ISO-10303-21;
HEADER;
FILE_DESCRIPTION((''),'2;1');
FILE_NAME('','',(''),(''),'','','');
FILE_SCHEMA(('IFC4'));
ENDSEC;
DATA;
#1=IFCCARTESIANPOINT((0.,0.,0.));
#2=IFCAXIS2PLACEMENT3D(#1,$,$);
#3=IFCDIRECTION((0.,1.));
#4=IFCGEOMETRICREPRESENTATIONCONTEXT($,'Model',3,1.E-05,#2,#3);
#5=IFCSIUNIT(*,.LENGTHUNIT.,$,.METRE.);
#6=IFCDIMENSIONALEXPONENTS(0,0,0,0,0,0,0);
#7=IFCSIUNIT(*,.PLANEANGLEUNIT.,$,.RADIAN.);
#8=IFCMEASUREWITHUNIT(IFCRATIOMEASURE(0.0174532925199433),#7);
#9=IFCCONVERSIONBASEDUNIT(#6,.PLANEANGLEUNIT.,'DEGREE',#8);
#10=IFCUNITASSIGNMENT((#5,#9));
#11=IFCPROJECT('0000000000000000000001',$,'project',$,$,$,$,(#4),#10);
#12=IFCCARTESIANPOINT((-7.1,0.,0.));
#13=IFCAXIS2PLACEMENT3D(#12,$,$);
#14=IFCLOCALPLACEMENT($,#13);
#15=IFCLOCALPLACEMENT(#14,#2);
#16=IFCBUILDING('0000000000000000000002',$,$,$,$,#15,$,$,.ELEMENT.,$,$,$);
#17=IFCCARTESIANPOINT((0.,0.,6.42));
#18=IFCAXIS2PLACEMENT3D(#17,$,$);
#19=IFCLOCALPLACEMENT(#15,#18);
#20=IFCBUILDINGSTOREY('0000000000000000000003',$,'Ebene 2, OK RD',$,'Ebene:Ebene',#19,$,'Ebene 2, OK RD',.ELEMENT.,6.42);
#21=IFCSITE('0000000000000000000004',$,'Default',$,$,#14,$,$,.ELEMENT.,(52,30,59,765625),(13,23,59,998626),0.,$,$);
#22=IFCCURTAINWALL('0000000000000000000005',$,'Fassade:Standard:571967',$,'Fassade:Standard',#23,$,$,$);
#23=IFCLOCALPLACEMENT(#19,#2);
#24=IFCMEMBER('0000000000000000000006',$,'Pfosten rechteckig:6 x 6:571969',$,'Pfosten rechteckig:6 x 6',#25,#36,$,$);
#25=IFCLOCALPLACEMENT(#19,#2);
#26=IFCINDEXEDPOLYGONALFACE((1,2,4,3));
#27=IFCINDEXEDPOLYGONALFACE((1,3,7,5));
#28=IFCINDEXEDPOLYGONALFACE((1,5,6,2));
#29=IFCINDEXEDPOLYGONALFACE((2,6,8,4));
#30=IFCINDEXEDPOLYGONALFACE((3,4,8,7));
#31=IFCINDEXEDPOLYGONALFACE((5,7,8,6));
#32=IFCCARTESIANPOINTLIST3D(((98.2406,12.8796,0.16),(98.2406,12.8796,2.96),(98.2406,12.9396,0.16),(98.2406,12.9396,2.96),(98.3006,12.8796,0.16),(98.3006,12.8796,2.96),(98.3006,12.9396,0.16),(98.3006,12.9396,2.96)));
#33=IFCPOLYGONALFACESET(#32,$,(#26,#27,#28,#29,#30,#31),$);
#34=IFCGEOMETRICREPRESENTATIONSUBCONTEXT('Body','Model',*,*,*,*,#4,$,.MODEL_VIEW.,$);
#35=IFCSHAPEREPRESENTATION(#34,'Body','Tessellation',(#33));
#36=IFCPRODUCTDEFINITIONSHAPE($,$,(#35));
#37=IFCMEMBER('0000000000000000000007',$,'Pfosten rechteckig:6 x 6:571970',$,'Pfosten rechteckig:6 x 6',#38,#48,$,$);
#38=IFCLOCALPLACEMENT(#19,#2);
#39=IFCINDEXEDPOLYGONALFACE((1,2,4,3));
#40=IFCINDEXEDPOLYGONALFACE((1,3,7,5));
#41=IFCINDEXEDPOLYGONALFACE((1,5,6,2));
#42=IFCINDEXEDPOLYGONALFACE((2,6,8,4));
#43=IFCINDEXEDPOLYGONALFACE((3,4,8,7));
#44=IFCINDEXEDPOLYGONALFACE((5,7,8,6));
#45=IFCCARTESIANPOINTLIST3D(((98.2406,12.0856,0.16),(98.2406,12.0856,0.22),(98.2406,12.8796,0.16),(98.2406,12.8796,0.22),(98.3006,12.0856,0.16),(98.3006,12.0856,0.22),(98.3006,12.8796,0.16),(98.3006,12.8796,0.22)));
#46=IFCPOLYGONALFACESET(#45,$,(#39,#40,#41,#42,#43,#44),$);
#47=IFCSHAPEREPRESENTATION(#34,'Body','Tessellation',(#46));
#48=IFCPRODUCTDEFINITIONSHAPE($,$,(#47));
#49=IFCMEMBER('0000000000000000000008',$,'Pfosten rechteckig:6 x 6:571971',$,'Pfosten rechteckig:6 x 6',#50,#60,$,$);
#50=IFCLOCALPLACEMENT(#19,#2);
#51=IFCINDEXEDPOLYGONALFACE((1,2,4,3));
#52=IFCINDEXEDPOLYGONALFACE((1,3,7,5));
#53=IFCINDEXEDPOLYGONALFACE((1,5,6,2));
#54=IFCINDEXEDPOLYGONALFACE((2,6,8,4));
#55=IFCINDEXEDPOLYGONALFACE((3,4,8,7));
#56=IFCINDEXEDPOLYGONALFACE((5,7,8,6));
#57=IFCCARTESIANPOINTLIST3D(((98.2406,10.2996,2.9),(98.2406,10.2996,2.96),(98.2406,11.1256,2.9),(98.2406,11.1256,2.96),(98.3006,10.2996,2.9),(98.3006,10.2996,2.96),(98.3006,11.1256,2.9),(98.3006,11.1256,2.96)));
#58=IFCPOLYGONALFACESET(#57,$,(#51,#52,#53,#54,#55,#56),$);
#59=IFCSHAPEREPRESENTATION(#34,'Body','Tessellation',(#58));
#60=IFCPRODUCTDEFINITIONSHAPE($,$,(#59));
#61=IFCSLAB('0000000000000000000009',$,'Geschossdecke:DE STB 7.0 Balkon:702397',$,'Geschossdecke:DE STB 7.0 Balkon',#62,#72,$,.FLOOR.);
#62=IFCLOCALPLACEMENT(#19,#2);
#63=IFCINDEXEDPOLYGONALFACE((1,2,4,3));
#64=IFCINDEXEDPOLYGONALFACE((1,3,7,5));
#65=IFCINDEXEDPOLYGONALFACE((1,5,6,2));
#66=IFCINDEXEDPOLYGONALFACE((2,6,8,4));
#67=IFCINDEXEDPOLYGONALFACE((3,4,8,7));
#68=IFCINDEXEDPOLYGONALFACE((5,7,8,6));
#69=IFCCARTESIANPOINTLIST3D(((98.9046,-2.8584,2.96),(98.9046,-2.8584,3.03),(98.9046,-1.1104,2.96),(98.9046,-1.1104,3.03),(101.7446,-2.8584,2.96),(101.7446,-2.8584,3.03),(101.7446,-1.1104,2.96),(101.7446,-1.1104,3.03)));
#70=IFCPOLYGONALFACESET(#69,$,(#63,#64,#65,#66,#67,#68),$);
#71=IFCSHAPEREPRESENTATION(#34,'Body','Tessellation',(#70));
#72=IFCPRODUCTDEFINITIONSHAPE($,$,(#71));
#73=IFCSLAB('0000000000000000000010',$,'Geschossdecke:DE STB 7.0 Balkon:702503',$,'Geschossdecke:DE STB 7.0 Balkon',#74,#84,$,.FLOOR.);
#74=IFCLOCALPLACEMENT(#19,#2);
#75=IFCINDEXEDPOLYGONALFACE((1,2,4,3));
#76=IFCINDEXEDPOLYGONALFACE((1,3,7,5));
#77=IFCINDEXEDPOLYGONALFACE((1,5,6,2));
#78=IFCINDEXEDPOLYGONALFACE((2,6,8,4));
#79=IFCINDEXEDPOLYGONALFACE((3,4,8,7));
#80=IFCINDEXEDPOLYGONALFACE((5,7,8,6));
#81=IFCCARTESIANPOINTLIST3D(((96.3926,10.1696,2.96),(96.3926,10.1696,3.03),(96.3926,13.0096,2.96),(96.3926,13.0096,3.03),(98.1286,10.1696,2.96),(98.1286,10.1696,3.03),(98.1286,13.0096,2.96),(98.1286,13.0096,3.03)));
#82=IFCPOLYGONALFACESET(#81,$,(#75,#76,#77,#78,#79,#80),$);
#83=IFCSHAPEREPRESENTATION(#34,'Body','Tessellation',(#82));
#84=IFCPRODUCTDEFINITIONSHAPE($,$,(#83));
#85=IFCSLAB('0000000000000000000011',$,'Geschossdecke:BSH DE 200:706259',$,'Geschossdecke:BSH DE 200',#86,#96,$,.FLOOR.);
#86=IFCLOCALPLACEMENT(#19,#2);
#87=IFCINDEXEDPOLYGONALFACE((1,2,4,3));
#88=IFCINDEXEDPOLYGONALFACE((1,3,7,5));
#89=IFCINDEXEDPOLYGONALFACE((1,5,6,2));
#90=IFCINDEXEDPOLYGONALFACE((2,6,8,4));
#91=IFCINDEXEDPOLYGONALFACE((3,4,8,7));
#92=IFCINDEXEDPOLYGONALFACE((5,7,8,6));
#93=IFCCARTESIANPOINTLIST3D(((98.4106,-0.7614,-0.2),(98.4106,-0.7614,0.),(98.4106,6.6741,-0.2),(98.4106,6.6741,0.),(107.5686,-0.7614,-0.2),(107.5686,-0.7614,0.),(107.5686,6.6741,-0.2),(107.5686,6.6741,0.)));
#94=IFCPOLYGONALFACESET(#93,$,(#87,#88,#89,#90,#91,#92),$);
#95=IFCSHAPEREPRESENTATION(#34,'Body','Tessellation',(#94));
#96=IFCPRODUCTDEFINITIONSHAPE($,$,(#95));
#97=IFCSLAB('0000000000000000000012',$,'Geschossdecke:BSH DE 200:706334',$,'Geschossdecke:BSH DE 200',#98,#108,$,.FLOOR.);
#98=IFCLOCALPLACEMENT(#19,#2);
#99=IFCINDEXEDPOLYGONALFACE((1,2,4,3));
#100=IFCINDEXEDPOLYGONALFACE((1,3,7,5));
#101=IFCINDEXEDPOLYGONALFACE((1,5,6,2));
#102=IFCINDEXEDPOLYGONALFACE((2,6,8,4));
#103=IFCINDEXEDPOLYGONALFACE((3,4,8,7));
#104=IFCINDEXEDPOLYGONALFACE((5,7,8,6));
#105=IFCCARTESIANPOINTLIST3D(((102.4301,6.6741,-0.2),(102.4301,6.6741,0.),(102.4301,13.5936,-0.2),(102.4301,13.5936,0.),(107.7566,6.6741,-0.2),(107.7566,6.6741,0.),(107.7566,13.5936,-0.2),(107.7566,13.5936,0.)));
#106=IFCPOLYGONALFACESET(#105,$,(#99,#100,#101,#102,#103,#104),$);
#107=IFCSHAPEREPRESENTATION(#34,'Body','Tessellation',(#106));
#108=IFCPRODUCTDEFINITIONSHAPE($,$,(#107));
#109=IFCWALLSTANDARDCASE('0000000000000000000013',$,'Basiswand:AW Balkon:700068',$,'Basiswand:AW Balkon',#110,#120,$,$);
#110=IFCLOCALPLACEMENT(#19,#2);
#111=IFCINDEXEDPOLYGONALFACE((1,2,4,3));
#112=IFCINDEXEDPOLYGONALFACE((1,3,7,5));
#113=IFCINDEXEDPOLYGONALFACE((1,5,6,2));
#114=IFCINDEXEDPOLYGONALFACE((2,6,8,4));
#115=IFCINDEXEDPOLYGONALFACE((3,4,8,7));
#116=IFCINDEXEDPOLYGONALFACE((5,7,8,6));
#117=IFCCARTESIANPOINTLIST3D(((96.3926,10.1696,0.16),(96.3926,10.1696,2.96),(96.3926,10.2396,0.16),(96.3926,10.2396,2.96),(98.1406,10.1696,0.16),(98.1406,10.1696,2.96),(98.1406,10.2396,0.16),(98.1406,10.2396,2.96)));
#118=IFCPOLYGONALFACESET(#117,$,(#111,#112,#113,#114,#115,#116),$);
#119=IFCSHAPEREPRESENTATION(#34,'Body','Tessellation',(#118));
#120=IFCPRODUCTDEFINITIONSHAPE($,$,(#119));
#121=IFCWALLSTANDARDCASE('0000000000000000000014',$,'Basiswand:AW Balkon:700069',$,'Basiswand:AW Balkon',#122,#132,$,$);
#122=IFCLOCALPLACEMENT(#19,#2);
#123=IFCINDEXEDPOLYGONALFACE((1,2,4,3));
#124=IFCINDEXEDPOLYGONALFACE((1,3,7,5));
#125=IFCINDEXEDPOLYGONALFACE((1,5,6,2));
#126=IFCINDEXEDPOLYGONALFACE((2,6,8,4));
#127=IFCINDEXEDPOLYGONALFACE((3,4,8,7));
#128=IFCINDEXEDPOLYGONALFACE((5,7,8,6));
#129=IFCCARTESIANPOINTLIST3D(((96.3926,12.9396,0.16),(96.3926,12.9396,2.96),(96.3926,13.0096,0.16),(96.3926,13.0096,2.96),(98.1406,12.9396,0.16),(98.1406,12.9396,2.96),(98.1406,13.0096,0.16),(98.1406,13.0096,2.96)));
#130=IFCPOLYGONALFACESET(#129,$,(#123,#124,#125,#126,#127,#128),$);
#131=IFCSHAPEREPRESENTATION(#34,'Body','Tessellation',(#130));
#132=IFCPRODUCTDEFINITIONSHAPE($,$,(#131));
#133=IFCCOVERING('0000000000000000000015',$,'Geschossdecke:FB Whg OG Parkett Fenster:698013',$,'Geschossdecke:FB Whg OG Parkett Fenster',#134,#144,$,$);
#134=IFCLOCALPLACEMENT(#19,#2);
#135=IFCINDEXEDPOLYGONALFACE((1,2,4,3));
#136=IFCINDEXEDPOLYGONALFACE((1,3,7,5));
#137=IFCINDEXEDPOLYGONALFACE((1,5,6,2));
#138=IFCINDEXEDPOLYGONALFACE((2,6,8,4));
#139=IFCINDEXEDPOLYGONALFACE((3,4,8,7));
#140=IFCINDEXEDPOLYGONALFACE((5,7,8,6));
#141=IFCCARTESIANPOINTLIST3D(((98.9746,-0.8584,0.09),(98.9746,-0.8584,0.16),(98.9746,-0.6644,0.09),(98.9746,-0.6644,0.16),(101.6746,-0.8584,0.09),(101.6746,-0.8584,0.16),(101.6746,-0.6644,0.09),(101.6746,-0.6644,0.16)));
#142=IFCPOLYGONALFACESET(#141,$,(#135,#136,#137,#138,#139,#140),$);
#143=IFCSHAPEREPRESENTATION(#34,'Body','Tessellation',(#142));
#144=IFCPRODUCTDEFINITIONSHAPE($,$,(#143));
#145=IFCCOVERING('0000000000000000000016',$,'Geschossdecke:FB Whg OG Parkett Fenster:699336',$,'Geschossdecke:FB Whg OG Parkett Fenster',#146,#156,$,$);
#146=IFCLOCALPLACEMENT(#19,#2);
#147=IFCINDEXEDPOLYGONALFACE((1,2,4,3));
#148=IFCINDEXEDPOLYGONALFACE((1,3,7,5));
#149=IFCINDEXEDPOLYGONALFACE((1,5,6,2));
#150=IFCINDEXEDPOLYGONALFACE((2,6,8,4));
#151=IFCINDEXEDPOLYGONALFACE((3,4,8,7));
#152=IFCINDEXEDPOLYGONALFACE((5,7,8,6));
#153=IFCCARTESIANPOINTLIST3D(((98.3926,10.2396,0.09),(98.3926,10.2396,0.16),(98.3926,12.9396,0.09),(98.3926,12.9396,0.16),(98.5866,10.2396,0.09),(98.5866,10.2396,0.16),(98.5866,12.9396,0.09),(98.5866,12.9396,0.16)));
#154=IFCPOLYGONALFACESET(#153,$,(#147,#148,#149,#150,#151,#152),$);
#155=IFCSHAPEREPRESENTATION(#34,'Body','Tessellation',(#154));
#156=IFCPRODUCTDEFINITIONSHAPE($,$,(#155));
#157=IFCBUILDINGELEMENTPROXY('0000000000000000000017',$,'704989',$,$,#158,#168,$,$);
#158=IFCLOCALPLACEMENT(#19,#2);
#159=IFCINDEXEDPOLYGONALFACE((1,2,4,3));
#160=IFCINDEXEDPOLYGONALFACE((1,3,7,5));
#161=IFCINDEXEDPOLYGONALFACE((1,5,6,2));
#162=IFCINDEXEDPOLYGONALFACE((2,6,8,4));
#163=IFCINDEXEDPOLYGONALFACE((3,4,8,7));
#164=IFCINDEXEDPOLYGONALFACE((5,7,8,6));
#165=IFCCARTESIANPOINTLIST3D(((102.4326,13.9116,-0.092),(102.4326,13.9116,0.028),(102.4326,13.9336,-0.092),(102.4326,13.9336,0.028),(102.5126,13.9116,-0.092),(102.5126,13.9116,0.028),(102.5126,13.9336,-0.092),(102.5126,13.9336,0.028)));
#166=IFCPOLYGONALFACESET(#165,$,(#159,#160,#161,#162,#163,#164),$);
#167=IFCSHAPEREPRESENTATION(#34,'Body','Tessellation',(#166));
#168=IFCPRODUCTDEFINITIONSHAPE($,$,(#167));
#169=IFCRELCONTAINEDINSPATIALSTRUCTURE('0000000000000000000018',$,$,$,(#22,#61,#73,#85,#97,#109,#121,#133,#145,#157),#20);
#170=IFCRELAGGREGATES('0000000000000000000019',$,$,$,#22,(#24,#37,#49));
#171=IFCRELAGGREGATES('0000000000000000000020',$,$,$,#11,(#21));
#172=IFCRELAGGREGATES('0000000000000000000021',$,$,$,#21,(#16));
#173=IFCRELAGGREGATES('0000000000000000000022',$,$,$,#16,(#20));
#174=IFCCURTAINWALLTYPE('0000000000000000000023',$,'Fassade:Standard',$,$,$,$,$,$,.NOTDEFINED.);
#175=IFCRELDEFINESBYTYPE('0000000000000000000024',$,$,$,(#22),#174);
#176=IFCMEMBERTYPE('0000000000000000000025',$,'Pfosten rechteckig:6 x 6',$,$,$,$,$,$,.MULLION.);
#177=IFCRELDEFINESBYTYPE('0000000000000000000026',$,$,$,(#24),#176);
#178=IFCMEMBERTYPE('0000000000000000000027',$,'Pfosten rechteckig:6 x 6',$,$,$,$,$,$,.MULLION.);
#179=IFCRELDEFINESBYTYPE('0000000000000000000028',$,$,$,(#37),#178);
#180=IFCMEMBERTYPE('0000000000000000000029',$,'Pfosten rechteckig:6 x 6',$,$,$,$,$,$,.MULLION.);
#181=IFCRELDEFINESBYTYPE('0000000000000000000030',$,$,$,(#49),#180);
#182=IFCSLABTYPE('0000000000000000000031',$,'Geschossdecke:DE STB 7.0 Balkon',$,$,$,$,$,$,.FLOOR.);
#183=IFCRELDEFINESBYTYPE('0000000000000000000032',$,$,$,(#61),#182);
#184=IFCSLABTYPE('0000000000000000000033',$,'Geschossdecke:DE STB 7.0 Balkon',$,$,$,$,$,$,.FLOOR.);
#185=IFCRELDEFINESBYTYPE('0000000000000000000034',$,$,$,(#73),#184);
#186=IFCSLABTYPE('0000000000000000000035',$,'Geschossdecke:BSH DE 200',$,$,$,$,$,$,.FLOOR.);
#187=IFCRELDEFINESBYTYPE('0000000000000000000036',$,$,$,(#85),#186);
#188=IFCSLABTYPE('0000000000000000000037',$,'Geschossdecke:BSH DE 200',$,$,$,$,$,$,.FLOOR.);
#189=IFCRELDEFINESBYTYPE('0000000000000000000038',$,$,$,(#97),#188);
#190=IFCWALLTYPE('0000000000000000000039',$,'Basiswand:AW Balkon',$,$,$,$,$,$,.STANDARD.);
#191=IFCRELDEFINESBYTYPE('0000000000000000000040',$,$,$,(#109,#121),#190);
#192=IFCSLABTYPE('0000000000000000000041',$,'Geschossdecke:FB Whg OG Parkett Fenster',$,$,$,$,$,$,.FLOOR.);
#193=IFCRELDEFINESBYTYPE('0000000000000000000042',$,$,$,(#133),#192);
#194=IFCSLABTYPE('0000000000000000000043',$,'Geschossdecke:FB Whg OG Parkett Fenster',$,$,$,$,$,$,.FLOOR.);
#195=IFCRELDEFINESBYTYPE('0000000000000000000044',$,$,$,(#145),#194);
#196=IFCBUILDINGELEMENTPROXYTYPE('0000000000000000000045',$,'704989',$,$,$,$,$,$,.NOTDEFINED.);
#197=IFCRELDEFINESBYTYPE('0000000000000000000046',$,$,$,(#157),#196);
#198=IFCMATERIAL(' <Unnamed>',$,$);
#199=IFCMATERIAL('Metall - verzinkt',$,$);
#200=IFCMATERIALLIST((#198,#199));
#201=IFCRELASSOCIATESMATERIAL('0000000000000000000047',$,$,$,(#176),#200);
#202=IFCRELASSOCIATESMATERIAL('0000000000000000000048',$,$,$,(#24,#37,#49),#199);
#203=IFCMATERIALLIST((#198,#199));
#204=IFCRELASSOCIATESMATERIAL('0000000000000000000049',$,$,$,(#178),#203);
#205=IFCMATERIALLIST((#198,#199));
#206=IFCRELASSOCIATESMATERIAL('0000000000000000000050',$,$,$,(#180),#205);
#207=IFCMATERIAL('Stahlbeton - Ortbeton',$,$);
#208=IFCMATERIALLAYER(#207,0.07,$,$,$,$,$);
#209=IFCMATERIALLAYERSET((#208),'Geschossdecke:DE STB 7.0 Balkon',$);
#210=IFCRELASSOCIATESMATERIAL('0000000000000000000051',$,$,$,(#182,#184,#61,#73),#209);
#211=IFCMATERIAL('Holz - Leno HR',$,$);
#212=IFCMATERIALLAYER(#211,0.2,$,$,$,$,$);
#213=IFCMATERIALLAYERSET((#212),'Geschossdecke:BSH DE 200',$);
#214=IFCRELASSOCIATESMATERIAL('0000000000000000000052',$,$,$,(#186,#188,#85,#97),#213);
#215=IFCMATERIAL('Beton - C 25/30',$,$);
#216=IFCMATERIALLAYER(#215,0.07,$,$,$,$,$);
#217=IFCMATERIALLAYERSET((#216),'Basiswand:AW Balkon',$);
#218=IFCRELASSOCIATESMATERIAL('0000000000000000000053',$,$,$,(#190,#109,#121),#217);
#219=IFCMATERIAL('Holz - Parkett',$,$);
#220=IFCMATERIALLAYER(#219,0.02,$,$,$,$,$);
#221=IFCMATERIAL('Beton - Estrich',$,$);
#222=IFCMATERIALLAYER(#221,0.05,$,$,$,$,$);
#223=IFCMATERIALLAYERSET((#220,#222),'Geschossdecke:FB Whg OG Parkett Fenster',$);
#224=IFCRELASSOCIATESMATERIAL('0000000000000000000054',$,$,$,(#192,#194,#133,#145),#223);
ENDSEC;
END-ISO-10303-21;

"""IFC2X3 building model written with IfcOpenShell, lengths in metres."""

from ifc_helpers import new_model, entity, si_unit, converted_unit, direction, frame, frame_2d, origin, origin_2d_with_axis, place, context, subcontext, project, spatial, rectangle, extrude, source, transform, mapped, material, material_list, layer, layer_set, layer_usage, type_object, type_shapes, element, aggregate, save


model = new_model("IFC2X3")

# Units and contexts
model_context = context("Model", 3, precision=1e-05, world=origin(), true_north=direction((0.0, 1.0)))
body_context = subcontext(model_context, "Body", "Model", "MODEL_VIEW")
ifc_project = project(units=[si_unit("LENGTHUNIT", "METRE"), converted_unit("PLANEANGLEUNIT", "DEGREE", entity("IfcRatioMeasure", 0.0174532925199433), si_unit("PLANEANGLEUNIT", "RADIAN"), dimensions=[0, 0, 0, 0, 0, 0, 0])], contexts=[model_context])

# Site, building, storey
site_placement = place(None, frame((-7.1, 0.0, 0.0)))
site = spatial("IfcSite", under=ifc_project, at=site_placement, Name="Default", CompositionType="ELEMENT", RefLatitude=(52, 30, 59, 765625), RefLongitude=(13, 23, 59, 998626), RefElevation=0.0)
building_placement = place(site_placement, origin())
building = spatial("IfcBuilding", under=site, at=building_placement, CompositionType="ELEMENT")
storey_placement = place(building_placement, frame((0.0, 0.0, 6.42)))
storey = spatial("IfcBuildingStorey", under=building, at=storey_placement, Name="Ebene 2, OK RD", ObjectType="Ebene:Ebene", LongName="Ebene 2, OK RD", CompositionType="ELEMENT", Elevation=6.42)

# Curtain wall, members
curtain_wall_type = type_object("IfcCurtainWallType", Name="Fassade:Standard", PredefinedType="NOTDEFINED")
curtain_wall_placement = place(storey_placement, frame((0.0, 0.0, -6.42)))
curtain_wall = element("IfcCurtainWall", 1, at=curtain_wall_placement, inside=storey, type_object=curtain_wall_type, Name="Fassade:Standard:571967", ObjectType="Fassade:Standard")
ifc_material_1 = material(Name="Metall - verzinkt")
ifc_material_2 = material(Name=" <Unnamed>")
ifc_material_list_1 = material_list([ifc_material_2, ifc_material_1])
member_type_1 = type_object("IfcMemberType", Name="Pfosten rechteckig:6 x 6", PredefinedType="MULLION", material=ifc_material_list_1)
shared_shape_1 = source(origin(), body_context, "Body", "SweptSolid", [
    extrude(rectangle(XDim=0.06, YDim=0.06, at=origin_2d_with_axis()), frame((-0.03, 0.0, -2.8), z_axis=(0.0, 0.0, 1.0), x_axis=(0.0, -1.0, 0.0)), (0.0, 0.0, 1.0), 2.8),
])
type_shapes(member_type_1, [shared_shape_1])
member_1_placement = place(storey_placement, frame((98.2706, 12.9396, 2.96), z_axis=(0.0, 0.0, 1.0), x_axis=(0.0, 1.0, 0.0)))
member_1 = element("IfcMember", 2, at=member_1_placement, type_object=member_type_1, material=ifc_material_1, Name="Pfosten rechteckig:6 x 6:571969", ObjectType="Pfosten rechteckig:6 x 6", context=body_context, shape_type="MappedRepresentation", body=[
    mapped(shared_shape_1, transform((0.0, 0.0, 0.0), scale=1.0)),
])
ifc_material_list_2 = material_list([ifc_material_2, ifc_material_1])
member_type_2 = type_object("IfcMemberType", Name="Pfosten rechteckig:6 x 6", PredefinedType="MULLION", material=ifc_material_list_2)
shared_shape_2 = source(origin(), body_context, "Body", "SweptSolid", [
    extrude(rectangle(XDim=0.06, YDim=0.06, at=origin_2d_with_axis()), frame((-0.03, 0.0, -0.794), z_axis=(0.0, 0.0, 1.0), x_axis=(0.0, -1.0, 0.0)), (0.0, 0.0, 1.0), 0.794),
])
type_shapes(member_type_2, [shared_shape_2])
member_2_placement = place(storey_placement, frame((98.2706, 12.8796, 0.16), z_axis=(0.0, 1.0, 0.0), x_axis=(0.0, 0.0, -1.0)))
member_2 = element("IfcMember", 3, at=member_2_placement, type_object=member_type_2, material=ifc_material_1, Name="Pfosten rechteckig:6 x 6:571970", ObjectType="Pfosten rechteckig:6 x 6", context=body_context, shape_type="MappedRepresentation", body=[
    mapped(shared_shape_2, transform((0.0, 0.0, 0.0), scale=1.0)),
])
ifc_material_list_3 = material_list([ifc_material_2, ifc_material_1])
member_type_3 = type_object("IfcMemberType", Name="Pfosten rechteckig:6 x 6", PredefinedType="MULLION", material=ifc_material_list_3)
shared_shape_3 = source(origin(), body_context, "Body", "SweptSolid", [
    extrude(rectangle(XDim=0.06, YDim=0.06, at=origin_2d_with_axis()), frame((-0.03, 0.0, -0.826), z_axis=(0.0, 0.0, 1.0), x_axis=(0.0, -1.0, 0.0)), (0.0, 0.0, 1.0), 0.826),
])
type_shapes(member_type_3, [shared_shape_3])
member_3_placement = place(storey_placement, frame((98.2706, 10.2996, 2.96), z_axis=(0.0, -1.0, 0.0), x_axis=(0.0, 0.0, 1.0)))
member_3 = element("IfcMember", 4, at=member_3_placement, type_object=member_type_3, material=ifc_material_1, Name="Pfosten rechteckig:6 x 6:571971", ObjectType="Pfosten rechteckig:6 x 6", context=body_context, shape_type="MappedRepresentation", body=[
    mapped(shared_shape_3, transform((0.0, 0.0, 0.0), scale=1.0)),
])
aggregate(curtain_wall, [member_1, member_2, member_3])

# Slabs
ifc_material_3 = material(Name="Stahlbeton - Ortbeton")
ifc_layer_1 = layer(ifc_material_3, 0.07)
ifc_layer_set_1 = layer_set([ifc_layer_1], Name="Geschossdecke:DE STB 7.0 Balkon")
ifc_layer_usage_1 = layer_usage(ifc_layer_set_1, "AXIS3", "POSITIVE", 0.0)
slab_type_1 = type_object("IfcSlabType", Name="Geschossdecke:DE STB 7.0 Balkon", PredefinedType="FLOOR", material=ifc_layer_set_1)
slab_1_placement = place(storey_placement, origin())
element("IfcSlab", 5, at=slab_1_placement, inside=storey, type_object=slab_type_1, material=ifc_layer_usage_1, Name="Geschossdecke:DE STB 7.0 Balkon:702397", ObjectType="Geschossdecke:DE STB 7.0 Balkon", PredefinedType="FLOOR", context=body_context, shape_type="SweptSolid", body=[
    extrude(rectangle(XDim=1.748, YDim=2.84, at=origin_2d_with_axis()), frame((100.3246, -1.9844, 3.03), z_axis=(0.0, 0.0, -1.0), x_axis=(0.0, 1.0, 0.0)), (0.0, 0.0, 1.0), 0.07),
])
ifc_layer_usage_2 = layer_usage(ifc_layer_set_1, "AXIS3", "POSITIVE", 0.0)
slab_type_2 = type_object("IfcSlabType", Name="Geschossdecke:DE STB 7.0 Balkon", PredefinedType="FLOOR", material=ifc_layer_set_1)
slab_2_placement = place(storey_placement, origin())
element("IfcSlab", 6, at=slab_2_placement, inside=storey, type_object=slab_type_2, material=ifc_layer_usage_2, Name="Geschossdecke:DE STB 7.0 Balkon:702503", ObjectType="Geschossdecke:DE STB 7.0 Balkon", PredefinedType="FLOOR", context=body_context, shape_type="SweptSolid", body=[
    extrude(rectangle(XDim=2.84, YDim=1.736, at=frame_2d((0.0, 0.0), x_axis=(1.0, 0.0))), frame((97.2606, 11.5896, 3.03), z_axis=(0.0, 0.0, -1.0), x_axis=(0.0, 1.0, 0.0)), (0.0, 0.0, 1.0), 0.07),
])
ifc_material_4 = material(Name="Holz - Leno HR")
ifc_layer_2 = layer(ifc_material_4, 0.2)
ifc_layer_set_2 = layer_set([ifc_layer_2], Name="Geschossdecke:BSH DE 200")
ifc_layer_usage_3 = layer_usage(ifc_layer_set_2, "AXIS3", "POSITIVE", 0.0)
slab_type_3 = type_object("IfcSlabType", Name="Geschossdecke:BSH DE 200", PredefinedType="FLOOR", material=ifc_layer_set_2)
slab_3_placement = place(storey_placement, origin())
element("IfcSlab", 7, at=slab_3_placement, inside=storey, type_object=slab_type_3, material=ifc_layer_usage_3, Name="Geschossdecke:BSH DE 200:706259", ObjectType="Geschossdecke:BSH DE 200", PredefinedType="FLOOR", context=body_context, shape_type="SweptSolid", body=[
    extrude(rectangle(XDim=7.4355, YDim=9.158, at=frame_2d((0.0, 0.0), x_axis=(1.0, 0.0))), frame((102.9896, 2.9564, 0.0), z_axis=(0.0, 0.0, -1.0), x_axis=(0.0, 1.0, 0.0)), (0.0, 0.0, 1.0), 0.2),
])
ifc_layer_usage_4 = layer_usage(ifc_layer_set_2, "AXIS3", "POSITIVE", 0.0)
slab_type_4 = type_object("IfcSlabType", Name="Geschossdecke:BSH DE 200", PredefinedType="FLOOR", material=ifc_layer_set_2)
slab_4_placement = place(storey_placement, origin())
element("IfcSlab", 8, at=slab_4_placement, inside=storey, type_object=slab_type_4, material=ifc_layer_usage_4, Name="Geschossdecke:BSH DE 200:706334", ObjectType="Geschossdecke:BSH DE 200", PredefinedType="FLOOR", context=body_context, shape_type="SweptSolid", body=[
    extrude(rectangle(XDim=6.9195, YDim=5.3265, at=frame_2d((0.0, 0.0), x_axis=(1.0, 0.0))), frame((105.0934, 10.1339, 0.0), z_axis=(0.0, 0.0, -1.0), x_axis=(0.0, 1.0, 0.0)), (0.0, 0.0, 1.0), 0.2),
])

# Walls
ifc_material_5 = material(Name="Beton - C 25/30")
ifc_layer_3 = layer(ifc_material_5, 0.07)
ifc_layer_set_3 = layer_set([ifc_layer_3], Name="Basiswand:AW Balkon")
ifc_layer_usage_5 = layer_usage(ifc_layer_set_3, "AXIS2", "NEGATIVE", 0.035)
wall_type = type_object("IfcWallType", Name="Basiswand:AW Balkon", PredefinedType="STANDARD", material=ifc_layer_set_3)
wall_1_placement = place(storey_placement, frame((98.1406, 10.2046, 0.16), z_axis=(0.0, 0.0, 1.0), x_axis=(-1.0, 0.0, 0.0)))
element("IfcWallStandardCase", 9, at=wall_1_placement, inside=storey, type_object=wall_type, material=ifc_layer_usage_5, Name="Basiswand:AW Balkon:700068", ObjectType="Basiswand:AW Balkon", context=body_context, shape_type="SweptSolid", body=[
    extrude(rectangle(XDim=1.748, YDim=0.07, at=frame_2d((0.874, 0.0), x_axis=(-1.0, 0.0))), origin(), (0.0, 0.0, 1.0), 2.8),
])
ifc_layer_usage_6 = layer_usage(ifc_layer_set_3, "AXIS2", "NEGATIVE", 0.035)
wall_2_placement = place(storey_placement, frame((96.3926, 12.9746, 0.16)))
element("IfcWallStandardCase", 10, at=wall_2_placement, inside=storey, type_object=wall_type, material=ifc_layer_usage_6, Name="Basiswand:AW Balkon:700069", ObjectType="Basiswand:AW Balkon", context=body_context, shape_type="SweptSolid", body=[
    extrude(rectangle(XDim=1.748, YDim=0.07, at=frame_2d((0.874, 0.0), x_axis=(-1.0, 0.0))), origin(), (0.0, 0.0, 1.0), 2.8),
])

# Coverings
ifc_material_6 = material(Name="Holz - Parkett")
ifc_layer_4 = layer(ifc_material_6, 0.02)
ifc_material_7 = material(Name="Beton - Estrich")
ifc_layer_5 = layer(ifc_material_7, 0.05)
ifc_layer_set_4 = layer_set([ifc_layer_4, ifc_layer_5], Name="Geschossdecke:FB Whg OG Parkett Fenster")
ifc_layer_usage_7 = layer_usage(ifc_layer_set_4, "AXIS3", "POSITIVE", 0.0)
slab_type_5 = type_object("IfcSlabType", Name="Geschossdecke:FB Whg OG Parkett Fenster", PredefinedType="FLOOR", material=ifc_layer_set_4)
covering_1_placement = place(storey_placement, origin())
element("IfcCovering", 11, at=covering_1_placement, inside=storey, type_object=slab_type_5, material=ifc_layer_usage_7, Name="Geschossdecke:FB Whg OG Parkett Fenster:698013", ObjectType="Geschossdecke:FB Whg OG Parkett Fenster", context=body_context, shape_type="SweptSolid", body=[
    extrude(rectangle(XDim=0.194, YDim=2.7, at=origin_2d_with_axis()), frame((100.3246, -0.7614, 0.16), z_axis=(0.0, 0.0, -1.0), x_axis=(0.0, 1.0, 0.0)), (0.0, 0.0, 1.0), 0.07),
])
ifc_layer_usage_8 = layer_usage(ifc_layer_set_4, "AXIS3", "POSITIVE", 0.0)
slab_type_6 = type_object("IfcSlabType", Name="Geschossdecke:FB Whg OG Parkett Fenster", PredefinedType="FLOOR", material=ifc_layer_set_4)
covering_2_placement = place(storey_placement, origin())
element("IfcCovering", 12, at=covering_2_placement, inside=storey, type_object=slab_type_6, material=ifc_layer_usage_8, Name="Geschossdecke:FB Whg OG Parkett Fenster:699336", ObjectType="Geschossdecke:FB Whg OG Parkett Fenster", context=body_context, shape_type="SweptSolid", body=[
    extrude(rectangle(XDim=2.7, YDim=0.194, at=frame_2d((0.0, 0.0), x_axis=(1.0, 0.0))), frame((98.4896, 11.5896, 0.16), z_axis=(0.0, 0.0, -1.0), x_axis=(0.0, 1.0, 0.0)), (0.0, 0.0, 1.0), 0.07),
])

# Building element proxy
building_element_proxy_type_1 = type_object("IfcBuildingElementProxyType", Name="704989", PredefinedType="NOTDEFINED")
proxy_1_placement = place(storey_placement, origin())
element("IfcBuildingElementProxy", 13, at=proxy_1_placement, inside=storey, type_object=building_element_proxy_type_1, Name="704989", context=body_context, shape_type="SweptSolid", body=[
    extrude(rectangle(XDim=0.08, YDim=0.022, at=frame_2d((0.0, 0.0), x_axis=(1.0, 0.0))), frame((102.4726, 13.9226, -0.092)), (0.0, 0.0, 1.0), 0.12),
])

save(model, "model.ifc")
